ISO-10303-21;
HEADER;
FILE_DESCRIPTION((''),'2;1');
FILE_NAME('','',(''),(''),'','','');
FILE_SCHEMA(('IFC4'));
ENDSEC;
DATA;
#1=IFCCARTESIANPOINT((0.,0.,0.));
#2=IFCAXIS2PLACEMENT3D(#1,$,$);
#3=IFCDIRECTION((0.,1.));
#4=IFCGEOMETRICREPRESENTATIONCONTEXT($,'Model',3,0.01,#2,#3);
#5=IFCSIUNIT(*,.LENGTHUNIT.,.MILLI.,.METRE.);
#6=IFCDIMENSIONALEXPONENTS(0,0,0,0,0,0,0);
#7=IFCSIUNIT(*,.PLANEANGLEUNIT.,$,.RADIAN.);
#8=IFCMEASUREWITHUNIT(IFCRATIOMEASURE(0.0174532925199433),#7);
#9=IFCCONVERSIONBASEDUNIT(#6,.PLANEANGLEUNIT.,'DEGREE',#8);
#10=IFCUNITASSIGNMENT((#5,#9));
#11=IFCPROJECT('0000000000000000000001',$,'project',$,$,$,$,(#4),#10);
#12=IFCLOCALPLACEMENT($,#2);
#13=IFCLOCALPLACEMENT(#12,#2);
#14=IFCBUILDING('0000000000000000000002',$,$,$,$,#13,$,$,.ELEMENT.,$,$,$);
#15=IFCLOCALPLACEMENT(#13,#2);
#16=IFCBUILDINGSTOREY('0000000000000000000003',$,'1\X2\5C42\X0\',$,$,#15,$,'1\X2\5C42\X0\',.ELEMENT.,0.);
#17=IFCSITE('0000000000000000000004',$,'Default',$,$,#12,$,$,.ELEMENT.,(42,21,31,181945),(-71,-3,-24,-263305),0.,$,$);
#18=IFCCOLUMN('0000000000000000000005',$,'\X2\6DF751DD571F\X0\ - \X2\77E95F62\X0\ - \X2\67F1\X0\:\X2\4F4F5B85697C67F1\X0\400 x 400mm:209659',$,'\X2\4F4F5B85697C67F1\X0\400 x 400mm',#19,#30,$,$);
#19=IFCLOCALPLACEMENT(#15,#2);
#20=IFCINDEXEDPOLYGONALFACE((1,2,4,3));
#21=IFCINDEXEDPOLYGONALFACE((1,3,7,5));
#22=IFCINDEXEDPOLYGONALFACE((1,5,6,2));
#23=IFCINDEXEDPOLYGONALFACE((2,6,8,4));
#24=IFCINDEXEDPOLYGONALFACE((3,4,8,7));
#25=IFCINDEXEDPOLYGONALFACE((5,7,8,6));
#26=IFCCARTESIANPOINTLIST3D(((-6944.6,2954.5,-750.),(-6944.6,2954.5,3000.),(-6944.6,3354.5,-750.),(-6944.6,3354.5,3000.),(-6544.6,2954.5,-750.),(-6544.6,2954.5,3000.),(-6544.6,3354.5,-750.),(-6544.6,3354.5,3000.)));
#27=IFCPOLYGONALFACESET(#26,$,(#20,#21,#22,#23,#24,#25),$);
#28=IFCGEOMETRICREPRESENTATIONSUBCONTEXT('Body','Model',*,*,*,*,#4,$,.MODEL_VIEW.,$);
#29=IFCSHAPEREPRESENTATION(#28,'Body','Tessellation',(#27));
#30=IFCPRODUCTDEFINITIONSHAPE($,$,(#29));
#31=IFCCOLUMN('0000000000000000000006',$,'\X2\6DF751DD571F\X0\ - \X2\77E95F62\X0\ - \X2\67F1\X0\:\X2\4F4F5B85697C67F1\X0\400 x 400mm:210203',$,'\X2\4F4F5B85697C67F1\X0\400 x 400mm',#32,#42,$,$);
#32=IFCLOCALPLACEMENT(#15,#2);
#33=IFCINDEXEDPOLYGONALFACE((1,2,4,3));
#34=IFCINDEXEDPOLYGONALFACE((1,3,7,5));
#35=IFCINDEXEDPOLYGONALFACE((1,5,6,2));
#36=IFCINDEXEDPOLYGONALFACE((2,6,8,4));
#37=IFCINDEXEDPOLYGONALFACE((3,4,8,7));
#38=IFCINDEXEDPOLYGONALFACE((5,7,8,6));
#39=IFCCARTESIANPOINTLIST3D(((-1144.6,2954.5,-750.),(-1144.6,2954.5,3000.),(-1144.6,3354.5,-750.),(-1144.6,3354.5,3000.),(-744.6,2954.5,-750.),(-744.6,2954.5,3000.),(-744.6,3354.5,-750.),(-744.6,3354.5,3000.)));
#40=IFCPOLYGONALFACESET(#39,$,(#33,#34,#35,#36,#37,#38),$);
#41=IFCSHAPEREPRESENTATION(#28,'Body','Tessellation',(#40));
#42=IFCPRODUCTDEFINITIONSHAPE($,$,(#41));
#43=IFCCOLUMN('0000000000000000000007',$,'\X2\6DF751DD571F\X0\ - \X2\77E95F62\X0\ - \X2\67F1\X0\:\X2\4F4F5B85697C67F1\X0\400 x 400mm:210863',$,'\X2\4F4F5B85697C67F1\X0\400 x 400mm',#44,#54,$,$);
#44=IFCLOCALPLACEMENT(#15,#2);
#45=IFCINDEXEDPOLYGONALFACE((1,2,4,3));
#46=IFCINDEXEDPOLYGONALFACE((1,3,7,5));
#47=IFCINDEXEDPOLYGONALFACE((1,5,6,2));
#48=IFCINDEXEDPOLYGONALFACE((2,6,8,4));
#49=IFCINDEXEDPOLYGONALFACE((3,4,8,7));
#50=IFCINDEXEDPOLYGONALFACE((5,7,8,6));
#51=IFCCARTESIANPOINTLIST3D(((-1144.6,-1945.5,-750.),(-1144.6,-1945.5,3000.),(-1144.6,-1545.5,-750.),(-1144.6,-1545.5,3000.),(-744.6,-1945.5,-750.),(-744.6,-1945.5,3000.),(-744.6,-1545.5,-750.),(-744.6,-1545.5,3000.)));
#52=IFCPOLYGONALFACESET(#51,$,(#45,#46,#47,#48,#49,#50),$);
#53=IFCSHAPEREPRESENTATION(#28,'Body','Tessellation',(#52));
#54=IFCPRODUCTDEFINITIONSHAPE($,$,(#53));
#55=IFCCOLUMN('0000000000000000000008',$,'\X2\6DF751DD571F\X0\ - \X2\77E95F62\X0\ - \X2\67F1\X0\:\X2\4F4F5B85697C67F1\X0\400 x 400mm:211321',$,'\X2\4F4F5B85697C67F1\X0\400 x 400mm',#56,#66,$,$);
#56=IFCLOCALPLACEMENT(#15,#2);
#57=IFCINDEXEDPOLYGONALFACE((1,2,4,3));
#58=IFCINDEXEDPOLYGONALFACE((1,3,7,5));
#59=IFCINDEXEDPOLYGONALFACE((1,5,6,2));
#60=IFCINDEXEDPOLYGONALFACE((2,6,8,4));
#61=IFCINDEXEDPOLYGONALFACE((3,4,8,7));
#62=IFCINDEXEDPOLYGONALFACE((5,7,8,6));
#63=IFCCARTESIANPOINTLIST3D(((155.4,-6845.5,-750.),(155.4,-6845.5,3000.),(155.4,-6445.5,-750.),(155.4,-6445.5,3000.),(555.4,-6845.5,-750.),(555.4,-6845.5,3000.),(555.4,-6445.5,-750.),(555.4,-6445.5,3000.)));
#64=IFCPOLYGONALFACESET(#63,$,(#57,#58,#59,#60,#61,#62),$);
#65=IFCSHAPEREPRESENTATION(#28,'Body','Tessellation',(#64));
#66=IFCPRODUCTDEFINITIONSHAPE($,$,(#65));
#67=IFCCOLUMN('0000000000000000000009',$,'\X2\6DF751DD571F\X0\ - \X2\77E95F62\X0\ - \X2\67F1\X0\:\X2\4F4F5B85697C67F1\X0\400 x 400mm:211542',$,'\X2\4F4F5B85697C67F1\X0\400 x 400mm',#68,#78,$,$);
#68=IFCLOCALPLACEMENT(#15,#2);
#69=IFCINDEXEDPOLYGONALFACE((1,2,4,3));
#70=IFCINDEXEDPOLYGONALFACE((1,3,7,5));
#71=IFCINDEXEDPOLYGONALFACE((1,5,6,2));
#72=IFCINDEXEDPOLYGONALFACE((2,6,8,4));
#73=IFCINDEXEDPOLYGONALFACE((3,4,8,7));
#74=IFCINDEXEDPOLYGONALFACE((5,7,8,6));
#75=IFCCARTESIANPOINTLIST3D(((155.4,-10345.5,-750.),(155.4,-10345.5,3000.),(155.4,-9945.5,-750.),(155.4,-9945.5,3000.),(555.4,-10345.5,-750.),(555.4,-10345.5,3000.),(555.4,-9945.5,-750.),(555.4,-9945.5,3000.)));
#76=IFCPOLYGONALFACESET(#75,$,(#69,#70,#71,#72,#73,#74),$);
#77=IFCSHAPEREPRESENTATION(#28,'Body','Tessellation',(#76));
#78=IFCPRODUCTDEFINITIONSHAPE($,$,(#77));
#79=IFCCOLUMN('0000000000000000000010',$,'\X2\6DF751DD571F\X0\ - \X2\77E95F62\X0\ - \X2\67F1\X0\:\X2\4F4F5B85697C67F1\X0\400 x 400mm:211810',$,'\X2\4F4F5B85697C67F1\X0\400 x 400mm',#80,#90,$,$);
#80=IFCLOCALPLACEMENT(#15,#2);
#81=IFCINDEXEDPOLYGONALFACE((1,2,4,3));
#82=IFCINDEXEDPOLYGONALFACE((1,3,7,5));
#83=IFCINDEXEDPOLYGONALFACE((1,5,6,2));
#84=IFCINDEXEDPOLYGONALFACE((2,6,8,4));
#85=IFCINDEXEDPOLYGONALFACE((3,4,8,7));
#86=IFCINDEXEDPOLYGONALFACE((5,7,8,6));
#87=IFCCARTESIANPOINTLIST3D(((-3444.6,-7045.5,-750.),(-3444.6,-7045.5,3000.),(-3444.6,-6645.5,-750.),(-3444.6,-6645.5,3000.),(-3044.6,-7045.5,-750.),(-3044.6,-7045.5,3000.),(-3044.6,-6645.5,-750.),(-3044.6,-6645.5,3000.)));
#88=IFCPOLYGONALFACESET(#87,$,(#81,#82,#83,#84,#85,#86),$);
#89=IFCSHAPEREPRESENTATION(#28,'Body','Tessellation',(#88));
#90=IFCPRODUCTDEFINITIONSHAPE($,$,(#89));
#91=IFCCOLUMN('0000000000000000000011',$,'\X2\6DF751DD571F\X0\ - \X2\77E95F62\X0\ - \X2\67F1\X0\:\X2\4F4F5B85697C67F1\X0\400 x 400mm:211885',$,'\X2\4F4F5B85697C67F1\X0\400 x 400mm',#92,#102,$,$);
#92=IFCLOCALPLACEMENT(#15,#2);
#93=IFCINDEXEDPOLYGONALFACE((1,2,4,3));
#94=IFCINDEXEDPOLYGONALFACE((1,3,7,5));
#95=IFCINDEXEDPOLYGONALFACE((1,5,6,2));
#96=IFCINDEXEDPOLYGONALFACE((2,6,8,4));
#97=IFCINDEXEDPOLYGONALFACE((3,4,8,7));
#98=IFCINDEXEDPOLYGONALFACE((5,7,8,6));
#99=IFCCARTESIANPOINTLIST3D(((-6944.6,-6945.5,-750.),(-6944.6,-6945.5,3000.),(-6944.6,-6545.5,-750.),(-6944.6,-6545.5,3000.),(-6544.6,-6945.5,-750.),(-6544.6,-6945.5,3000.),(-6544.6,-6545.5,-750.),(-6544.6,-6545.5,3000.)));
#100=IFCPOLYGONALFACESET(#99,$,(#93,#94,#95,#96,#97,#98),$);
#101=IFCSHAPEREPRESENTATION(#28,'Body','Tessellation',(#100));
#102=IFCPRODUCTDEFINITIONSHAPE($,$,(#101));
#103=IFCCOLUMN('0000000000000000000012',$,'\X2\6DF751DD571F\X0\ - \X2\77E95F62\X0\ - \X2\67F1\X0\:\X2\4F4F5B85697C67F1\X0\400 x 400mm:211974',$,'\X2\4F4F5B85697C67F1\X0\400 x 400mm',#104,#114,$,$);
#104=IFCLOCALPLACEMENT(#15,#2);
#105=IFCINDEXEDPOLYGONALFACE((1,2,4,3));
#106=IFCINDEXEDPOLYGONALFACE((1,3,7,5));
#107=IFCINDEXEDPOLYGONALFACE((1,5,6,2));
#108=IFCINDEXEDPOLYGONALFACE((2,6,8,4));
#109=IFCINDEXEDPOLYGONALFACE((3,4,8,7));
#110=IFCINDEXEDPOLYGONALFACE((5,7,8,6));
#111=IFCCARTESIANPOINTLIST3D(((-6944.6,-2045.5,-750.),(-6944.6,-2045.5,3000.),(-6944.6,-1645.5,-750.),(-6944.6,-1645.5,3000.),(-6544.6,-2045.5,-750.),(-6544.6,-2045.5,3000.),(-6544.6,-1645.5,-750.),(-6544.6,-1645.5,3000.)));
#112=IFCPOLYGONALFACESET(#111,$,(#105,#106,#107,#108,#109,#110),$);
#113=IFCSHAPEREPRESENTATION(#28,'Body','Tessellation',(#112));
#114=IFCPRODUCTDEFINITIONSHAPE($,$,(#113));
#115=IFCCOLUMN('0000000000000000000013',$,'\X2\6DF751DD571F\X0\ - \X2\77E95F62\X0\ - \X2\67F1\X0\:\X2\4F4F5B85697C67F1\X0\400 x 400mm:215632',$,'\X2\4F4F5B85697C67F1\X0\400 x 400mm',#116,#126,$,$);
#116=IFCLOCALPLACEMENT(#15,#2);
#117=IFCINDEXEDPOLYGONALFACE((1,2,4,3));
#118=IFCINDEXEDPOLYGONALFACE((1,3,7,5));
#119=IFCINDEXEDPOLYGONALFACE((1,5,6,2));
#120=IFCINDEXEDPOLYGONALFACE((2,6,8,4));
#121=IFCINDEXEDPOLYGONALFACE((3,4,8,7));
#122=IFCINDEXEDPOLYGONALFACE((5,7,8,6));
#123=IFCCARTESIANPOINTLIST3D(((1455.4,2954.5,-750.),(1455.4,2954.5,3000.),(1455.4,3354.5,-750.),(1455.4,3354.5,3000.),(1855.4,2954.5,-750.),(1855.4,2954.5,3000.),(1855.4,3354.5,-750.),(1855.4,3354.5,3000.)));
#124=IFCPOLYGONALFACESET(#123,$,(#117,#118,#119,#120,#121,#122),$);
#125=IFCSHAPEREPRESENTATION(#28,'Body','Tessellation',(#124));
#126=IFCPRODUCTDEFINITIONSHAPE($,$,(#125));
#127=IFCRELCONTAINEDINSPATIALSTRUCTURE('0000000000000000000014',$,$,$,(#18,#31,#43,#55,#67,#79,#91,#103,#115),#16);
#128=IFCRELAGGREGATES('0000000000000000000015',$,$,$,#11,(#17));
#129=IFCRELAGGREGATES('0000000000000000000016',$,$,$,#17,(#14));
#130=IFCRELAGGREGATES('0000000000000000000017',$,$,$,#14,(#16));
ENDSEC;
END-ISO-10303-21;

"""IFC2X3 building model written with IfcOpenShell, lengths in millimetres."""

from ifc_helpers import new_model, entity, si_unit, converted_unit, direction, frame, frame_2d, origin, origin_2d_with_axis, place, context, subcontext, project, spatial, rectangle, extrude, source, transform, mapped, element, save


model = new_model("IFC2X3")

# Units and contexts
model_context = context("Model", 3, precision=0.01, world=origin(), true_north=direction((0.0, 1.0)))
body_context = subcontext(model_context, "Body", "Model", "MODEL_VIEW")
ifc_project = project(units=[si_unit("LENGTHUNIT", "METRE", prefix="MILLI"), converted_unit("PLANEANGLEUNIT", "DEGREE", entity("IfcRatioMeasure", 0.0174532925199433), si_unit("PLANEANGLEUNIT", "RADIAN"), dimensions=[0, 0, 0, 0, 0, 0, 0])], contexts=[model_context])

# Site, building, storey
site_placement = place(None, origin())
site = spatial("IfcSite", under=ifc_project, at=site_placement, Name="Default", CompositionType="ELEMENT", RefLatitude=(42, 21, 31, 181945), RefLongitude=(-71, -3, -24, -263305), RefElevation=0.0)
building_placement = place(site_placement, origin())
building = spatial("IfcBuilding", under=site, at=building_placement, CompositionType="ELEMENT")
storey_placement = place(building_placement, origin())
storey = spatial("IfcBuildingStorey", under=building, at=storey_placement, Name="1层", LongName="1层", CompositionType="ELEMENT", Elevation=0.0)

# Columns
shared_shape_1 = source(origin(), body_context, "Body", "SweptSolid", [
    extrude(rectangle(XDim=400.0, YDim=400.0, at=origin_2d_with_axis()), frame((-6744.6, 3154.5, -750.0), z_axis=(0.0, 0.0, 1.0), x_axis=(0.0, -1.0, 0.0)), (0.0, 0.0, 1.0), 3750.0),
])
column_1_placement = place(storey_placement, origin())
element("IfcColumn", 1, at=column_1_placement, inside=storey, Name="混凝土 - 矩形 - 柱:住宅楼柱400 x 400mm:209659", ObjectType="住宅楼柱400 x 400mm", context=body_context, shape_type="MappedRepresentation", body=[
    mapped(shared_shape_1, transform((0.0, 0.0, 0.0), scale=1.0)),
])
shared_shape_2 = source(origin(), body_context, "Body", "SweptSolid", [
    extrude(rectangle(XDim=400.0, YDim=400.0, at=origin_2d_with_axis()), frame((-944.6, 3154.5, -750.0), z_axis=(0.0, 0.0, 1.0), x_axis=(0.0, -1.0, 0.0)), (0.0, 0.0, 1.0), 3750.0),
])
column_2_placement = place(storey_placement, origin())
element("IfcColumn", 2, at=column_2_placement, inside=storey, Name="混凝土 - 矩形 - 柱:住宅楼柱400 x 400mm:210203", ObjectType="住宅楼柱400 x 400mm", context=body_context, shape_type="MappedRepresentation", body=[
    mapped(shared_shape_2, transform((0.0, 0.0, 0.0), scale=1.0)),
])
shared_shape_3 = source(origin(), body_context, "Body", "SweptSolid", [
    extrude(rectangle(XDim=400.0, YDim=400.0, at=origin_2d_with_axis()), frame((-944.6, -1745.5, -750.0), z_axis=(0.0, 0.0, 1.0), x_axis=(0.0, -1.0, 0.0)), (0.0, 0.0, 1.0), 3750.0),
])
column_3_placement = place(storey_placement, origin())
element("IfcColumn", 3, at=column_3_placement, inside=storey, Name="混凝土 - 矩形 - 柱:住宅楼柱400 x 400mm:210863", ObjectType="住宅楼柱400 x 400mm", context=body_context, shape_type="MappedRepresentation", body=[
    mapped(shared_shape_3, transform((0.0, 0.0, 0.0), scale=1.0)),
])
shared_shape_4 = source(origin(), body_context, "Body", "SweptSolid", [
    extrude(rectangle(XDim=400.0, YDim=400.0, at=frame_2d((0.0, 0.0), x_axis=(1.0, 0.0))), frame((355.4, -6645.5, -750.0), z_axis=(0.0, 0.0, 1.0), x_axis=(0.0, -1.0, 0.0)), (0.0, 0.0, 1.0), 3750.0),
])
column_4_placement = place(storey_placement, origin())
element("IfcColumn", 4, at=column_4_placement, inside=storey, Name="混凝土 - 矩形 - 柱:住宅楼柱400 x 400mm:211321", ObjectType="住宅楼柱400 x 400mm", context=body_context, shape_type="MappedRepresentation", body=[
    mapped(shared_shape_4, transform((0.0, 0.0, 0.0), scale=1.0)),
])
shared_shape_5 = source(origin(), body_context, "Body", "SweptSolid", [
    extrude(rectangle(XDim=400.0, YDim=400.0, at=frame_2d((0.0, 0.0), x_axis=(1.0, 0.0))), frame((355.4, -10145.5, -750.0), z_axis=(0.0, 0.0, 1.0), x_axis=(0.0, -1.0, 0.0)), (0.0, 0.0, 1.0), 3750.0),
])
column_5_placement = place(storey_placement, origin())
element("IfcColumn", 5, at=column_5_placement, inside=storey, Name="混凝土 - 矩形 - 柱:住宅楼柱400 x 400mm:211542", ObjectType="住宅楼柱400 x 400mm", context=body_context, shape_type="MappedRepresentation", body=[
    mapped(shared_shape_5, transform((0.0, 0.0, 0.0), scale=1.0)),
])
shared_shape_6 = source(origin(), body_context, "Body", "SweptSolid", [
    extrude(rectangle(XDim=400.0, YDim=400.0, at=origin_2d_with_axis()), frame((-3244.6, -6845.5, -750.0), z_axis=(0.0, 0.0, 1.0), x_axis=(0.0, -1.0, 0.0)), (0.0, 0.0, 1.0), 3750.0),
])
column_6_placement = place(storey_placement, origin())
element("IfcColumn", 6, at=column_6_placement, inside=storey, Name="混凝土 - 矩形 - 柱:住宅楼柱400 x 400mm:211810", ObjectType="住宅楼柱400 x 400mm", context=body_context, shape_type="MappedRepresentation", body=[
    mapped(shared_shape_6, transform((0.0, 0.0, 0.0), scale=1.0)),
])
shared_shape_7 = source(origin(), body_context, "Body", "SweptSolid", [
    extrude(rectangle(XDim=400.0, YDim=400.0, at=origin_2d_with_axis()), frame((-6744.6, -6745.5, -750.0), z_axis=(0.0, 0.0, 1.0), x_axis=(0.0, -1.0, 0.0)), (0.0, 0.0, 1.0), 3750.0),
])
column_7_placement = place(storey_placement, origin())
element("IfcColumn", 7, at=column_7_placement, inside=storey, Name="混凝土 - 矩形 - 柱:住宅楼柱400 x 400mm:211885", ObjectType="住宅楼柱400 x 400mm", context=body_context, shape_type="MappedRepresentation", body=[
    mapped(shared_shape_7, transform((0.0, 0.0, 0.0), scale=1.0)),
])
shared_shape_8 = source(origin(), body_context, "Body", "SweptSolid", [
    extrude(rectangle(XDim=400.0, YDim=400.0, at=origin_2d_with_axis()), frame((-6744.6, -1845.5, -750.0), z_axis=(0.0, 0.0, 1.0), x_axis=(0.0, -1.0, 0.0)), (0.0, 0.0, 1.0), 3750.0),
])
column_8_placement = place(storey_placement, origin())
element("IfcColumn", 8, at=column_8_placement, inside=storey, Name="混凝土 - 矩形 - 柱:住宅楼柱400 x 400mm:211974", ObjectType="住宅楼柱400 x 400mm", context=body_context, shape_type="MappedRepresentation", body=[
    mapped(shared_shape_8, transform((0.0, 0.0, 0.0), scale=1.0)),
])
shared_shape_9 = source(origin(), body_context, "Body", "SweptSolid", [
    extrude(rectangle(XDim=400.0, YDim=400.0, at=origin_2d_with_axis()), frame((1655.4, 3154.5, -750.0), z_axis=(0.0, 0.0, 1.0), x_axis=(0.0, -1.0, 0.0)), (0.0, 0.0, 1.0), 3750.0),
])
column_9_placement = place(storey_placement, origin())
element("IfcColumn", 9, at=column_9_placement, inside=storey, Name="混凝土 - 矩形 - 柱:住宅楼柱400 x 400mm:215632", ObjectType="住宅楼柱400 x 400mm", context=body_context, shape_type="MappedRepresentation", body=[
    mapped(shared_shape_9, transform((0.0, 0.0, 0.0), scale=1.0)),
])

save(model, "model.ifc")
